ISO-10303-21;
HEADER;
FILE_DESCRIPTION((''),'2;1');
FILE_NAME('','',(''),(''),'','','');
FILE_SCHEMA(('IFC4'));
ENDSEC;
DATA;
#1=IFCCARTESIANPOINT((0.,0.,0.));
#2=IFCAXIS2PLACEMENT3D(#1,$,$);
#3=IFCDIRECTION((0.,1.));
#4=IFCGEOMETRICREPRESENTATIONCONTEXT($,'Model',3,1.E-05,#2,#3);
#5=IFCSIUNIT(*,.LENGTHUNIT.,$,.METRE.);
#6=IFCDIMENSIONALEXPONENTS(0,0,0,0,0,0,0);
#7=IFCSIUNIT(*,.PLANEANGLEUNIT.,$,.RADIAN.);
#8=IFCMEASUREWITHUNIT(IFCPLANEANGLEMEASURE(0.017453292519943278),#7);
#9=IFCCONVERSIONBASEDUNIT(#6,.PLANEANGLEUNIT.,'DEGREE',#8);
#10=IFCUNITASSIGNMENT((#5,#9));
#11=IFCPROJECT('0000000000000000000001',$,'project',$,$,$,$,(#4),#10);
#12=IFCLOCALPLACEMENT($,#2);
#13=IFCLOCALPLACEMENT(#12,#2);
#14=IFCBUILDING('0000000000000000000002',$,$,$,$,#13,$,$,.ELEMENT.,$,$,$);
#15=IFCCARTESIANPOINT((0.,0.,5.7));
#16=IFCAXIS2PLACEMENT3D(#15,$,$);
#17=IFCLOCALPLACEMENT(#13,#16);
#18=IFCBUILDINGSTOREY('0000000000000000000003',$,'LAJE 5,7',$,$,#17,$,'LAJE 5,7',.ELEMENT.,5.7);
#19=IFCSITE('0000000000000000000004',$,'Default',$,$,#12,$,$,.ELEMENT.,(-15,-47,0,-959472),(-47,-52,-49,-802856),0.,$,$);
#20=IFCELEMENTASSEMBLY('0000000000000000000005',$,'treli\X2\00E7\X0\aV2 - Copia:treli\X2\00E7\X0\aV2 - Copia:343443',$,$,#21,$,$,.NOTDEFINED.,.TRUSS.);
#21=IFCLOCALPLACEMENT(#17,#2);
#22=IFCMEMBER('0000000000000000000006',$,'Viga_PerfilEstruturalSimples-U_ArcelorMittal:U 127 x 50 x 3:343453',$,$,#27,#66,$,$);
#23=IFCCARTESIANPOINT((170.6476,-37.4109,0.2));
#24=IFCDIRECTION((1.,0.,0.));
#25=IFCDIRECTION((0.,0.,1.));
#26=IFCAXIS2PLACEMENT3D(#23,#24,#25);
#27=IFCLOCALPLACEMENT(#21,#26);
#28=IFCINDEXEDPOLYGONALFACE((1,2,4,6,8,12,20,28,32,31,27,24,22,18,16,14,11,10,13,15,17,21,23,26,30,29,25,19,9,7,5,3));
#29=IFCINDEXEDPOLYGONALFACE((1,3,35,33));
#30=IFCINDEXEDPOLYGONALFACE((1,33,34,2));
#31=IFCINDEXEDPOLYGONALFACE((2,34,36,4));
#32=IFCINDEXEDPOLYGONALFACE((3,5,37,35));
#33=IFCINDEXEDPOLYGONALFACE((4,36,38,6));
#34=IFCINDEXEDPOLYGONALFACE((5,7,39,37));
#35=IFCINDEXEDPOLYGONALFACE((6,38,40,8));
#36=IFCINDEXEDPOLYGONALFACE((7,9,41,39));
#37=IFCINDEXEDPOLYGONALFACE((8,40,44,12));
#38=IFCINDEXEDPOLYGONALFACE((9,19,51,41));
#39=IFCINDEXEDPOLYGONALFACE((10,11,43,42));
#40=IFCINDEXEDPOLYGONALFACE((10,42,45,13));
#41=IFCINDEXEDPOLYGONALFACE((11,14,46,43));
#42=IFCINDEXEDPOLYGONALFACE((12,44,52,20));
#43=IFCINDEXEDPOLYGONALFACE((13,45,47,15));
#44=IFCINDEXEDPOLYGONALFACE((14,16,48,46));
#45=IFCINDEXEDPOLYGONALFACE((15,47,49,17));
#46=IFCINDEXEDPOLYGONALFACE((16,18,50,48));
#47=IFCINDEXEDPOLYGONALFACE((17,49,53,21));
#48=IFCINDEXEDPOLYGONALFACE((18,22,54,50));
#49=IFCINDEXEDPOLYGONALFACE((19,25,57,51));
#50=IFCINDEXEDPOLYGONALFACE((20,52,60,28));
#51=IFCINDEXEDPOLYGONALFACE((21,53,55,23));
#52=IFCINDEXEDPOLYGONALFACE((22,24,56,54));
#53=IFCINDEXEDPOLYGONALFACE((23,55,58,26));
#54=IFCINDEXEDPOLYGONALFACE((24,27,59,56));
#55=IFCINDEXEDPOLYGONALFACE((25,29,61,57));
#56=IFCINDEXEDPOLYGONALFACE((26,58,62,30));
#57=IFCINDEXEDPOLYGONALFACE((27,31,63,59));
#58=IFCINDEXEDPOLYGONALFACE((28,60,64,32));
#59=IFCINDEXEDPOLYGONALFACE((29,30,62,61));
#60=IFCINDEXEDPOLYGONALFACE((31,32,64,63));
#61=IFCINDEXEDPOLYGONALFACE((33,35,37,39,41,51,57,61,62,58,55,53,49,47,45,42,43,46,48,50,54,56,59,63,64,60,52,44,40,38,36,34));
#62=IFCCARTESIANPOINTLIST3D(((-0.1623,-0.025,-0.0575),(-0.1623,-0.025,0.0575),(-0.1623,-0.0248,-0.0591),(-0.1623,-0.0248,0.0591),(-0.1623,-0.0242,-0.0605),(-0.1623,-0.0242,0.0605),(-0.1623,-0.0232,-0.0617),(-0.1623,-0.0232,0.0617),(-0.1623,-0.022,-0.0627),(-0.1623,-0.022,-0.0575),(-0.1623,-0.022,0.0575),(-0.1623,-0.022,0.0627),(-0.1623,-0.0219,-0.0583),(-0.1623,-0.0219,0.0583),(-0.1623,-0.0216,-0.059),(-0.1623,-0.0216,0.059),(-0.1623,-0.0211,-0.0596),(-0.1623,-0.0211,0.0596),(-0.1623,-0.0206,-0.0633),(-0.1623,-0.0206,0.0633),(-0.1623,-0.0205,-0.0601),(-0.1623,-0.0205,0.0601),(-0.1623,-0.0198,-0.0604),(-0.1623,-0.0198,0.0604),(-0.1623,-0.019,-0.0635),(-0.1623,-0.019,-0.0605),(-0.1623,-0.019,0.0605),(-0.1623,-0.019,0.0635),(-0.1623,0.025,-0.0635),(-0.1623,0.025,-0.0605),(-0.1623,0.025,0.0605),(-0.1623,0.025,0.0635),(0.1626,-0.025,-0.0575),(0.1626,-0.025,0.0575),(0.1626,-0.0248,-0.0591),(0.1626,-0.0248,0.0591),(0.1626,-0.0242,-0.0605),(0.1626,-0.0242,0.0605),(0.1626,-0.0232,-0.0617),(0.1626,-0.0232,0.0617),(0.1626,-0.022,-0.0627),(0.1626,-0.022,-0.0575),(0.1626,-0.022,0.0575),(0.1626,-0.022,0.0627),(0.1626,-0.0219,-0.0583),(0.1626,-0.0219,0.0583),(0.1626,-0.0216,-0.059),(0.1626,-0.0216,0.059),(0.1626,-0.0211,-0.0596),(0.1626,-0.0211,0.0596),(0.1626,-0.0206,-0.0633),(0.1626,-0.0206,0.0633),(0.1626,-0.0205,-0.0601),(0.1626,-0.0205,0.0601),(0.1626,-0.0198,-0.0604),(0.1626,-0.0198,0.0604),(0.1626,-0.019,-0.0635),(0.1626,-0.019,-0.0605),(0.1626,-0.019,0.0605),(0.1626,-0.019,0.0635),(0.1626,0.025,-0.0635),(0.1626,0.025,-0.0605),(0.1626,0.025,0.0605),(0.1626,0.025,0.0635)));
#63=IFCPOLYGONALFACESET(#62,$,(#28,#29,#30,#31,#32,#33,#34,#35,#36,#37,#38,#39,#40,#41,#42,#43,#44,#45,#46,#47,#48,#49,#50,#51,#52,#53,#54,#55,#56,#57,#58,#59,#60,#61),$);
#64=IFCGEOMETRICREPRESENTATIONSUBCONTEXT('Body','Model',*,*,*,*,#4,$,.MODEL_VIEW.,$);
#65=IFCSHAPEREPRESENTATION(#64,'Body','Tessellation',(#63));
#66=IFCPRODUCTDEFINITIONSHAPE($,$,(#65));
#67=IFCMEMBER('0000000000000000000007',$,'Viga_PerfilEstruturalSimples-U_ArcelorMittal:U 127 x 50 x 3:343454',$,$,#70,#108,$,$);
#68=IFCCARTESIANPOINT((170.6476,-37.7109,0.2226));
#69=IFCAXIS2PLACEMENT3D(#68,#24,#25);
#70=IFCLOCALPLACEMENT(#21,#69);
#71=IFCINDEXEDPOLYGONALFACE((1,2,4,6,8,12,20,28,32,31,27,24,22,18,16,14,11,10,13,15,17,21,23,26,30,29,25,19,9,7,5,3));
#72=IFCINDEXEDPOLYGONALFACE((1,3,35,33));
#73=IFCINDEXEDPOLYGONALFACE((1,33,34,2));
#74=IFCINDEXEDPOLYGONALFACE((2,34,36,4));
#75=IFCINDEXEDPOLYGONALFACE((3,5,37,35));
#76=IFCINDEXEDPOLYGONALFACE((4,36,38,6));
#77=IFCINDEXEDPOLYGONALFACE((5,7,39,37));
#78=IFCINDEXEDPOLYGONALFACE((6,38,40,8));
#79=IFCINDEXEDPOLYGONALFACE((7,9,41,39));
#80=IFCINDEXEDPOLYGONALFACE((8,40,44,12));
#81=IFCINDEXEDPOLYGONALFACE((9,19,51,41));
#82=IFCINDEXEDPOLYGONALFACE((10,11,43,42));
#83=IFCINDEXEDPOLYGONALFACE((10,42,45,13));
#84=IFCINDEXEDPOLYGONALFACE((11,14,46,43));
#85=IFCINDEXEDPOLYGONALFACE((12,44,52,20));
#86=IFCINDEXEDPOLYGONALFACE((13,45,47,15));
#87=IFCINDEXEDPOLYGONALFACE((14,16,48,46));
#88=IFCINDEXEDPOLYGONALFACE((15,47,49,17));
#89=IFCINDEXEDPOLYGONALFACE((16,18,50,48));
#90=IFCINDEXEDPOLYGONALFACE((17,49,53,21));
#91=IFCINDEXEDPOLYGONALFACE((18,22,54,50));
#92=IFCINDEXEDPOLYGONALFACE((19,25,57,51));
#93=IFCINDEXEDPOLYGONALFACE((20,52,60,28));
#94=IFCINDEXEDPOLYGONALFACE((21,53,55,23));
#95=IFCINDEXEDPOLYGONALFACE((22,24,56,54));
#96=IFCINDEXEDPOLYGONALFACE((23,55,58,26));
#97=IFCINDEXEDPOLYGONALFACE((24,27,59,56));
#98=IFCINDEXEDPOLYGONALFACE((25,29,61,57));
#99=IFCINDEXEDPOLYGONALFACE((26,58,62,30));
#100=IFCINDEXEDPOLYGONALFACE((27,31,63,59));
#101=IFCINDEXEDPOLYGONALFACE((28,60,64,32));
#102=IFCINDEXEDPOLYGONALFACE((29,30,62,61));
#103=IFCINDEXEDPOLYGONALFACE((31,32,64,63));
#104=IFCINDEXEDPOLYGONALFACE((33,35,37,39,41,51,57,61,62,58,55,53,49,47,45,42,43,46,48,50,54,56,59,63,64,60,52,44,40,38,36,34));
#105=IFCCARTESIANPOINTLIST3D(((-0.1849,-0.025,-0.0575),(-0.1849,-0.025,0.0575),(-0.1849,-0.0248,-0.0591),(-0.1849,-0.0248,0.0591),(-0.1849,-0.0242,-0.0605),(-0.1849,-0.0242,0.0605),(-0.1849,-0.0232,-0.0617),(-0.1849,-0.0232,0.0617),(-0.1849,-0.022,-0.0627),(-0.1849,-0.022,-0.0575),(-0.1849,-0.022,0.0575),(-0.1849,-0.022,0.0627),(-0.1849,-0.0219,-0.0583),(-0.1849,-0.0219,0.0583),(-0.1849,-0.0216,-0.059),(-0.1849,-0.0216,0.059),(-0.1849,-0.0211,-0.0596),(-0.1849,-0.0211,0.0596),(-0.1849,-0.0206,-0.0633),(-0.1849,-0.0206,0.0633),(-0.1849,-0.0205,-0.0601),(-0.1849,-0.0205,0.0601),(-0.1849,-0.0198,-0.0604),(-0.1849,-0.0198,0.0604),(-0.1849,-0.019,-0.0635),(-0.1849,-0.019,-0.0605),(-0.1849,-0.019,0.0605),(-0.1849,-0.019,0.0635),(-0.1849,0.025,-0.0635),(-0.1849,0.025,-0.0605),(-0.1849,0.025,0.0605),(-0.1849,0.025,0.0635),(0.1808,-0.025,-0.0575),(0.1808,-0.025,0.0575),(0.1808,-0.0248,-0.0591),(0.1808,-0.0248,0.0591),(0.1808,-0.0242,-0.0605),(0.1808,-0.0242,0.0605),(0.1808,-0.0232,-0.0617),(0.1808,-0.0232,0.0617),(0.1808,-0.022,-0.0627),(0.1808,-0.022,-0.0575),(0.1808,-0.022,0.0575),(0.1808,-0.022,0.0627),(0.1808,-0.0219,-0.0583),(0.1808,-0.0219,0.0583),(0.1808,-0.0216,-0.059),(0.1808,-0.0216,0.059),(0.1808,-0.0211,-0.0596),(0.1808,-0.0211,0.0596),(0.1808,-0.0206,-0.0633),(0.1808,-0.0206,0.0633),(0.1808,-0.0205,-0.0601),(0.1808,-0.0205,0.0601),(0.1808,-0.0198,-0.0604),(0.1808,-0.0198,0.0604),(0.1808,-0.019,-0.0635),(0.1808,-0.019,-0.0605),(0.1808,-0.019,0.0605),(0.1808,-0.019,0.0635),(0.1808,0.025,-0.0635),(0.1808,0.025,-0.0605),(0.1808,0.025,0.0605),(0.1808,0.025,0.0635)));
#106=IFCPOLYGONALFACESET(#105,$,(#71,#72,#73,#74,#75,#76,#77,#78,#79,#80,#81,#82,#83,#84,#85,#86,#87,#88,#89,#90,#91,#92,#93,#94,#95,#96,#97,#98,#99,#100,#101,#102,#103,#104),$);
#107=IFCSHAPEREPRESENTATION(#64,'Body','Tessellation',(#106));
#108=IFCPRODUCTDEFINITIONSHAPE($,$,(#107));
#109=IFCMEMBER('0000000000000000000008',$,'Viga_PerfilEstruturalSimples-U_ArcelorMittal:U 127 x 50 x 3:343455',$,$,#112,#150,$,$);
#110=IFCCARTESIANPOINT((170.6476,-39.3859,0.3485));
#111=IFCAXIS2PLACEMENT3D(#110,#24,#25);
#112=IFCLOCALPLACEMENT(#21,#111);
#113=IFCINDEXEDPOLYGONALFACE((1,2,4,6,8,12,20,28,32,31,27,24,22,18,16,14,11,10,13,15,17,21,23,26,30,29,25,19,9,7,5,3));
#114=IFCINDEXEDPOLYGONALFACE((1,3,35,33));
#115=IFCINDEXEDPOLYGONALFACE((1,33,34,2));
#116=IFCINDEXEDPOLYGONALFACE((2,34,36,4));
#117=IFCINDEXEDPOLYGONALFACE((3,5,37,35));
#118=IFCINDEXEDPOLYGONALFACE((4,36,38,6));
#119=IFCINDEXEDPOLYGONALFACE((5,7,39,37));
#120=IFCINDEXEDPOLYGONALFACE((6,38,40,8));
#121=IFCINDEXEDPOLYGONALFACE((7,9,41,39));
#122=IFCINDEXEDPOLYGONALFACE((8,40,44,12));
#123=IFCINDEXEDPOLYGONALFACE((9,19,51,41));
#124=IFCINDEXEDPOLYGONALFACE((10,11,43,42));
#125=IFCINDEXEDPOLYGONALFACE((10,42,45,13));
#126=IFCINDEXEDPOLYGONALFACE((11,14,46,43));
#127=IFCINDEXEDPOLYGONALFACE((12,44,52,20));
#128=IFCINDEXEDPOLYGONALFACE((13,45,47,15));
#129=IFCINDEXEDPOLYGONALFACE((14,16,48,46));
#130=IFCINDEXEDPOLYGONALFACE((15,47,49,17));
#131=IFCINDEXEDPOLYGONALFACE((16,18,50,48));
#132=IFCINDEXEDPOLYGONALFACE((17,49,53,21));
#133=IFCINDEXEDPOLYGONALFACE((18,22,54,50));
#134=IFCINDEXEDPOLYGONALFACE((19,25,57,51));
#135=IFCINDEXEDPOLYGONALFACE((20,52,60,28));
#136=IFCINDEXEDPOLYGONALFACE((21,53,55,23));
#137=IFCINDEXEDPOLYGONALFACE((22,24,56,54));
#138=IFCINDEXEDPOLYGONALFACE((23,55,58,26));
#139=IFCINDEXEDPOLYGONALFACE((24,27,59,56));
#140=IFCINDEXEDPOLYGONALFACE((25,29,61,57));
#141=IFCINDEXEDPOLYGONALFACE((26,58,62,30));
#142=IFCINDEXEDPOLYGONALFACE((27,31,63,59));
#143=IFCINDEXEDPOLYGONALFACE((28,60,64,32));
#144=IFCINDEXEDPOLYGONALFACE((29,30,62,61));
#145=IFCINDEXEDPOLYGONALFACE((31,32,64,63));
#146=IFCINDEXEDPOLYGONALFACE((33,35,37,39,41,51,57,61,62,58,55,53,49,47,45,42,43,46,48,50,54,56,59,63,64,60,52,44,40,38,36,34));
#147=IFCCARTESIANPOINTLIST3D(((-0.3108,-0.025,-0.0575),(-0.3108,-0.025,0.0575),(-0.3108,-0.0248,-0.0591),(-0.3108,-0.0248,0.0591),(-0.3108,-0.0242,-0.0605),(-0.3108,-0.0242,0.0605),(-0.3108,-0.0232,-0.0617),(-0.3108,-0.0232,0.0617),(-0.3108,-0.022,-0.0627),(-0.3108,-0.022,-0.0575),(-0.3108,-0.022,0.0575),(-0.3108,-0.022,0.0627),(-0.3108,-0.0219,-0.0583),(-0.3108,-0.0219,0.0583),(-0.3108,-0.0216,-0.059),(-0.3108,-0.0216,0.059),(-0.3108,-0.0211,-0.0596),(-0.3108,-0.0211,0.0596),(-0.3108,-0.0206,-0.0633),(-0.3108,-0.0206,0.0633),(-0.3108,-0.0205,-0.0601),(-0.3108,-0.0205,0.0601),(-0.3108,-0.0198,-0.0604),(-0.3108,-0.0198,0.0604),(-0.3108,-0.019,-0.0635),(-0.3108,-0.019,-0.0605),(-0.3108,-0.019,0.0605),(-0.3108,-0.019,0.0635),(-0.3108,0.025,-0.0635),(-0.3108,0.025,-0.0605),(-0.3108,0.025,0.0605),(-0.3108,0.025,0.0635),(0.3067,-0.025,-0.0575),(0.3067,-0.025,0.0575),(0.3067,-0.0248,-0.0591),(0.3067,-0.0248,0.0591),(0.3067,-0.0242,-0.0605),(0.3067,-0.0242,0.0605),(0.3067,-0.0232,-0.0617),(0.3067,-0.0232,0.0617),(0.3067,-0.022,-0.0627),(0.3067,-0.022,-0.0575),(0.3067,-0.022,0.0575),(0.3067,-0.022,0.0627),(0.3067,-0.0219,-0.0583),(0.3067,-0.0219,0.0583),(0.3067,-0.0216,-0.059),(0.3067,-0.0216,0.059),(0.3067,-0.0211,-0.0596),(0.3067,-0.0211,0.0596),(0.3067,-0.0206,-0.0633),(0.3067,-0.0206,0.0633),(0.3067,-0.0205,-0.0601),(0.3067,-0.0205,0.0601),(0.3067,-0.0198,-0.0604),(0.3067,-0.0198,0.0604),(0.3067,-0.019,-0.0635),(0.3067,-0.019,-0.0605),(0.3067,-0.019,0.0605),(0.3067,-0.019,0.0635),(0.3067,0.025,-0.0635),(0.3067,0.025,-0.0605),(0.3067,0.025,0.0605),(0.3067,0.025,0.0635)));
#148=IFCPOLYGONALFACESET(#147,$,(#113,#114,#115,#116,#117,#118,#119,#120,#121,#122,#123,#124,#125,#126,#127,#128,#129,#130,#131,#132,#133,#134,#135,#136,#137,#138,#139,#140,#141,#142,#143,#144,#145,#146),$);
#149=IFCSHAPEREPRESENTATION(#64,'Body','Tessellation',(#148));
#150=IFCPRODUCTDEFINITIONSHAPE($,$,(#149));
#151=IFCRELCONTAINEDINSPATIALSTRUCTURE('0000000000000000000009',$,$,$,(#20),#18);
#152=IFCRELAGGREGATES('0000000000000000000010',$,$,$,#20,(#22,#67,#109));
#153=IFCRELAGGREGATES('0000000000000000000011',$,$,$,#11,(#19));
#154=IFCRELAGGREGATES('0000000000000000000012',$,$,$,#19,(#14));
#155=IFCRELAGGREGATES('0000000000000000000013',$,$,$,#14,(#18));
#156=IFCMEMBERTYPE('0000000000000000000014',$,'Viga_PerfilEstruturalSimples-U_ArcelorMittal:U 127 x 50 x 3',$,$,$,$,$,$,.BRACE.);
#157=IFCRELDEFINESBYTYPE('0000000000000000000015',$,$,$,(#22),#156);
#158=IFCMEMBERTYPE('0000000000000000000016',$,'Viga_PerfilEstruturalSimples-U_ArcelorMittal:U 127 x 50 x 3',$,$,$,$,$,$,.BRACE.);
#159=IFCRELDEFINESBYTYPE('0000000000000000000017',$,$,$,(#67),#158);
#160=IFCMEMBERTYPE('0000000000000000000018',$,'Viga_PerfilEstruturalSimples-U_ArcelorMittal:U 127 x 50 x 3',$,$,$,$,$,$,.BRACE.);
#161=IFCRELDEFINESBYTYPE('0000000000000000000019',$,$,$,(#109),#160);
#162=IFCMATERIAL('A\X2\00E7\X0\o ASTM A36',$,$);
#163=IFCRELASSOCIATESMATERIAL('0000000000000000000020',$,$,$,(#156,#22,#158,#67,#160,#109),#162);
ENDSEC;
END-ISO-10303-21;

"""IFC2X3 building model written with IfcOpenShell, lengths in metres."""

from ifc_helpers import new_model, entity, si_unit, converted_unit, direction, frame, frame_2d, origin, place, context, subcontext, project, spatial, polyline, circle_curve, parameter, trimmed, segment, composite_curve, outline, extrude, source, transform, mapped, material, type_object, type_shapes, element, aggregate, save


model = new_model("IFC2X3")

# Units and contexts
model_context = context("Model", 3, precision=1e-05, world=origin(), true_north=direction((0.0, 1.0)))
body_context = subcontext(model_context, "Body", "Model", "MODEL_VIEW")
ifc_project = project(units=[si_unit("LENGTHUNIT", "METRE"), converted_unit("PLANEANGLEUNIT", "DEGREE", entity("IfcPlaneAngleMeasure", 0.017453292519943278), si_unit("PLANEANGLEUNIT", "RADIAN"), dimensions=[0, 0, 0, 0, 0, 0, 0])], contexts=[model_context])

# Site, building, storey
site_placement = place(None, origin())
site = spatial("IfcSite", under=ifc_project, at=site_placement, Name="Default", CompositionType="ELEMENT", RefLatitude=(-15, -47, 0, -959472), RefLongitude=(-47, -52, -49, -802856), RefElevation=0.0)
building_placement = place(site_placement, origin())
building = spatial("IfcBuilding", under=site, at=building_placement, CompositionType="ELEMENT")
storey_placement = place(building_placement, frame((0.0, 0.0, 5.7)))
storey = spatial("IfcBuildingStorey", under=building, at=storey_placement, Name="LAJE 5,7", LongName="LAJE 5,7", CompositionType="ELEMENT", Elevation=5.7)

# Element assembly, member
ifc_material = material(Name="Aço ASTM A36")
member_type_1 = type_object("IfcMemberType", Name="Viga_PerfilEstruturalSimples-U_ArcelorMittal:U 127 x 50 x 3", PredefinedType="BRACE", material=ifc_material)
shared_shape_1 = source(origin(), body_context, "Body", "SweptSolid", [
    extrude(outline(composite_curve([segment(polyline([(-0.0575, -0.0192), (0.0575, -0.0192)]), True, "CONTINUOUS"), segment(trimmed(circle_curve(frame_2d((0.0575, -0.0132), x_axis=(0.0, 1.0)), 0.006), [parameter(180.0)], [parameter(270.0)], True, "PARAMETER"), True, "CONTINUOUS"), segment(polyline([(0.0635, -0.0132), (0.0635, 0.0308)]), True, "CONTINUOUS"), segment(polyline([(0.0635, 0.0308), (0.0605, 0.0308)]), True, "CONTINUOUS"), segment(polyline([(0.0605, 0.0308), (0.0605, -0.0132)]), True, "CONTINUOUS"), segment(trimmed(circle_curve(frame_2d((0.0575, -0.0132), x_axis=(0.0, 1.0)), 0.003), [parameter(180.0)], [parameter(270.0)], True, "PARAMETER"), False, "CONTINUOUS"), segment(polyline([(0.0575, -0.0162), (-0.0575, -0.0162)]), True, "CONTINUOUS"), segment(trimmed(circle_curve(frame_2d((-0.0575, -0.0132), x_axis=(0.0, 1.0)), 0.003), [parameter(90.0)], [parameter(180.0)], True, "PARAMETER"), False, "CONTINUOUS"), segment(polyline([(-0.0605, -0.0132), (-0.0605, 0.0308)]), True, "CONTINUOUS"), segment(polyline([(-0.0605, 0.0308), (-0.0635, 0.0308)]), True, "CONTINUOUS"), segment(polyline([(-0.0635, 0.0308), (-0.0635, -0.0132)]), True, "CONTINUOUS"), segment(trimmed(circle_curve(frame_2d((-0.0575, -0.0132), x_axis=(0.0, 1.0)), 0.006), [parameter(90.0)], [parameter(180.0)], True, "PARAMETER"), True, "CONTINUOUS")], self_intersect=False)), frame((-0.1623, -0.0058, 0.0), z_axis=(1.0, 0.0, 0.0), x_axis=(0.0, 0.0, -1.0)), (0.0, 0.0, 1.0), 0.3249),
])
type_shapes(member_type_1, [shared_shape_1])
assembly_1_placement = place(storey_placement, origin())
assembly_1 = element("IfcElementAssembly", 1, at=assembly_1_placement, inside=storey, Name="treliçaV2 - Copia:treliçaV2 - Copia:343443", AssemblyPlace="NOTDEFINED", PredefinedType="TRUSS")
member_1_placement = place(assembly_1_placement, frame((170.6476, -37.4109, 0.2), z_axis=(1.0, 0.0, 0.0), x_axis=(0.0, 0.0, 1.0)))
member_1 = element("IfcMember", 2, at=member_1_placement, type_object=member_type_1, material=ifc_material, Name="Viga_PerfilEstruturalSimples-U_ArcelorMittal:U 127 x 50 x 3:343453", context=body_context, shape_type="MappedRepresentation", body=[
    mapped(shared_shape_1, transform((0.0, 0.0, 0.0), scale=1.0)),
])

# Members
member_type_2 = type_object("IfcMemberType", Name="Viga_PerfilEstruturalSimples-U_ArcelorMittal:U 127 x 50 x 3", PredefinedType="BRACE", material=ifc_material)
shared_shape_2 = source(origin(), body_context, "Body", "SweptSolid", [
    extrude(outline(composite_curve([segment(polyline([(-0.0575, -0.0192), (0.0575, -0.0192)]), True, "CONTINUOUS"), segment(trimmed(circle_curve(frame_2d((0.0575, -0.0132), x_axis=(0.0, 1.0)), 0.006), [parameter(180.0)], [parameter(270.0)], True, "PARAMETER"), True, "CONTINUOUS"), segment(polyline([(0.0635, -0.0132), (0.0635, 0.0308)]), True, "CONTINUOUS"), segment(polyline([(0.0635, 0.0308), (0.0605, 0.0308)]), True, "CONTINUOUS"), segment(polyline([(0.0605, 0.0308), (0.0605, -0.0132)]), True, "CONTINUOUS"), segment(trimmed(circle_curve(frame_2d((0.0575, -0.0132), x_axis=(0.0, 1.0)), 0.003), [parameter(180.0)], [parameter(270.0)], True, "PARAMETER"), False, "CONTINUOUS"), segment(polyline([(0.0575, -0.0162), (-0.0575, -0.0162)]), True, "CONTINUOUS"), segment(trimmed(circle_curve(frame_2d((-0.0575, -0.0132), x_axis=(0.0, 1.0)), 0.003), [parameter(90.0)], [parameter(180.0)], True, "PARAMETER"), False, "CONTINUOUS"), segment(polyline([(-0.0605, -0.0132), (-0.0605, 0.0308)]), True, "CONTINUOUS"), segment(polyline([(-0.0605, 0.0308), (-0.0635, 0.0308)]), True, "CONTINUOUS"), segment(polyline([(-0.0635, 0.0308), (-0.0635, -0.0132)]), True, "CONTINUOUS"), segment(trimmed(circle_curve(frame_2d((-0.0575, -0.0132), x_axis=(0.0, 1.0)), 0.006), [parameter(90.0)], [parameter(180.0)], True, "PARAMETER"), True, "CONTINUOUS")], self_intersect=False)), frame((-0.1849, -0.0058, 0.0), z_axis=(1.0, 0.0, 0.0), x_axis=(0.0, 0.0, -1.0)), (0.0, 0.0, 1.0), 0.3657),
])
type_shapes(member_type_2, [shared_shape_2])
member_2_placement = place(assembly_1_placement, frame((170.6476, -37.7109, 0.2226), z_axis=(1.0, 0.0, 0.0), x_axis=(0.0, 0.0, 1.0)))
member_2 = element("IfcMember", 3, at=member_2_placement, type_object=member_type_2, material=ifc_material, Name="Viga_PerfilEstruturalSimples-U_ArcelorMittal:U 127 x 50 x 3:343454", context=body_context, shape_type="MappedRepresentation", body=[
    mapped(shared_shape_2, transform((0.0, 0.0, 0.0), scale=1.0)),
])
member_type_3 = type_object("IfcMemberType", Name="Viga_PerfilEstruturalSimples-U_ArcelorMittal:U 127 x 50 x 3", PredefinedType="BRACE", material=ifc_material)
shared_shape_3 = source(origin(), body_context, "Body", "SweptSolid", [
    extrude(outline(composite_curve([segment(polyline([(-0.0575, -0.0192), (0.0575, -0.0192)]), True, "CONTINUOUS"), segment(trimmed(circle_curve(frame_2d((0.0575, -0.0132), x_axis=(0.0, 1.0)), 0.006), [parameter(180.0)], [parameter(270.0)], True, "PARAMETER"), True, "CONTINUOUS"), segment(polyline([(0.0635, -0.0132), (0.0635, 0.0308)]), True, "CONTINUOUS"), segment(polyline([(0.0635, 0.0308), (0.0605, 0.0308)]), True, "CONTINUOUS"), segment(polyline([(0.0605, 0.0308), (0.0605, -0.0132)]), True, "CONTINUOUS"), segment(trimmed(circle_curve(frame_2d((0.0575, -0.0132), x_axis=(0.0, 1.0)), 0.003), [parameter(180.0)], [parameter(270.0)], True, "PARAMETER"), False, "CONTINUOUS"), segment(polyline([(0.0575, -0.0162), (-0.0575, -0.0162)]), True, "CONTINUOUS"), segment(trimmed(circle_curve(frame_2d((-0.0575, -0.0132), x_axis=(0.0, 1.0)), 0.003), [parameter(90.0)], [parameter(180.0)], True, "PARAMETER"), False, "CONTINUOUS"), segment(polyline([(-0.0605, -0.0132), (-0.0605, 0.0308)]), True, "CONTINUOUS"), segment(polyline([(-0.0605, 0.0308), (-0.0635, 0.0308)]), True, "CONTINUOUS"), segment(polyline([(-0.0635, 0.0308), (-0.0635, -0.0132)]), True, "CONTINUOUS"), segment(trimmed(circle_curve(frame_2d((-0.0575, -0.0132), x_axis=(0.0, 1.0)), 0.006), [parameter(90.0)], [parameter(180.0)], True, "PARAMETER"), True, "CONTINUOUS")], self_intersect=False)), frame((-0.3108, -0.0058, 0.0), z_axis=(1.0, 0.0, 0.0), x_axis=(0.0, 0.0, -1.0)), (0.0, 0.0, 1.0), 0.6175),
])
type_shapes(member_type_3, [shared_shape_3])
member_3_placement = place(assembly_1_placement, frame((170.6476, -39.3859, 0.3485), z_axis=(1.0, 0.0, 0.0), x_axis=(0.0, 0.0, 1.0)))
member_3 = element("IfcMember", 4, at=member_3_placement, type_object=member_type_3, material=ifc_material, Name="Viga_PerfilEstruturalSimples-U_ArcelorMittal:U 127 x 50 x 3:343455", context=body_context, shape_type="MappedRepresentation", body=[
    mapped(shared_shape_3, transform((0.0, 0.0, 0.0), scale=1.0)),
])
aggregate(assembly_1, [member_1, member_2, member_3])

save(model, "model.ifc")
